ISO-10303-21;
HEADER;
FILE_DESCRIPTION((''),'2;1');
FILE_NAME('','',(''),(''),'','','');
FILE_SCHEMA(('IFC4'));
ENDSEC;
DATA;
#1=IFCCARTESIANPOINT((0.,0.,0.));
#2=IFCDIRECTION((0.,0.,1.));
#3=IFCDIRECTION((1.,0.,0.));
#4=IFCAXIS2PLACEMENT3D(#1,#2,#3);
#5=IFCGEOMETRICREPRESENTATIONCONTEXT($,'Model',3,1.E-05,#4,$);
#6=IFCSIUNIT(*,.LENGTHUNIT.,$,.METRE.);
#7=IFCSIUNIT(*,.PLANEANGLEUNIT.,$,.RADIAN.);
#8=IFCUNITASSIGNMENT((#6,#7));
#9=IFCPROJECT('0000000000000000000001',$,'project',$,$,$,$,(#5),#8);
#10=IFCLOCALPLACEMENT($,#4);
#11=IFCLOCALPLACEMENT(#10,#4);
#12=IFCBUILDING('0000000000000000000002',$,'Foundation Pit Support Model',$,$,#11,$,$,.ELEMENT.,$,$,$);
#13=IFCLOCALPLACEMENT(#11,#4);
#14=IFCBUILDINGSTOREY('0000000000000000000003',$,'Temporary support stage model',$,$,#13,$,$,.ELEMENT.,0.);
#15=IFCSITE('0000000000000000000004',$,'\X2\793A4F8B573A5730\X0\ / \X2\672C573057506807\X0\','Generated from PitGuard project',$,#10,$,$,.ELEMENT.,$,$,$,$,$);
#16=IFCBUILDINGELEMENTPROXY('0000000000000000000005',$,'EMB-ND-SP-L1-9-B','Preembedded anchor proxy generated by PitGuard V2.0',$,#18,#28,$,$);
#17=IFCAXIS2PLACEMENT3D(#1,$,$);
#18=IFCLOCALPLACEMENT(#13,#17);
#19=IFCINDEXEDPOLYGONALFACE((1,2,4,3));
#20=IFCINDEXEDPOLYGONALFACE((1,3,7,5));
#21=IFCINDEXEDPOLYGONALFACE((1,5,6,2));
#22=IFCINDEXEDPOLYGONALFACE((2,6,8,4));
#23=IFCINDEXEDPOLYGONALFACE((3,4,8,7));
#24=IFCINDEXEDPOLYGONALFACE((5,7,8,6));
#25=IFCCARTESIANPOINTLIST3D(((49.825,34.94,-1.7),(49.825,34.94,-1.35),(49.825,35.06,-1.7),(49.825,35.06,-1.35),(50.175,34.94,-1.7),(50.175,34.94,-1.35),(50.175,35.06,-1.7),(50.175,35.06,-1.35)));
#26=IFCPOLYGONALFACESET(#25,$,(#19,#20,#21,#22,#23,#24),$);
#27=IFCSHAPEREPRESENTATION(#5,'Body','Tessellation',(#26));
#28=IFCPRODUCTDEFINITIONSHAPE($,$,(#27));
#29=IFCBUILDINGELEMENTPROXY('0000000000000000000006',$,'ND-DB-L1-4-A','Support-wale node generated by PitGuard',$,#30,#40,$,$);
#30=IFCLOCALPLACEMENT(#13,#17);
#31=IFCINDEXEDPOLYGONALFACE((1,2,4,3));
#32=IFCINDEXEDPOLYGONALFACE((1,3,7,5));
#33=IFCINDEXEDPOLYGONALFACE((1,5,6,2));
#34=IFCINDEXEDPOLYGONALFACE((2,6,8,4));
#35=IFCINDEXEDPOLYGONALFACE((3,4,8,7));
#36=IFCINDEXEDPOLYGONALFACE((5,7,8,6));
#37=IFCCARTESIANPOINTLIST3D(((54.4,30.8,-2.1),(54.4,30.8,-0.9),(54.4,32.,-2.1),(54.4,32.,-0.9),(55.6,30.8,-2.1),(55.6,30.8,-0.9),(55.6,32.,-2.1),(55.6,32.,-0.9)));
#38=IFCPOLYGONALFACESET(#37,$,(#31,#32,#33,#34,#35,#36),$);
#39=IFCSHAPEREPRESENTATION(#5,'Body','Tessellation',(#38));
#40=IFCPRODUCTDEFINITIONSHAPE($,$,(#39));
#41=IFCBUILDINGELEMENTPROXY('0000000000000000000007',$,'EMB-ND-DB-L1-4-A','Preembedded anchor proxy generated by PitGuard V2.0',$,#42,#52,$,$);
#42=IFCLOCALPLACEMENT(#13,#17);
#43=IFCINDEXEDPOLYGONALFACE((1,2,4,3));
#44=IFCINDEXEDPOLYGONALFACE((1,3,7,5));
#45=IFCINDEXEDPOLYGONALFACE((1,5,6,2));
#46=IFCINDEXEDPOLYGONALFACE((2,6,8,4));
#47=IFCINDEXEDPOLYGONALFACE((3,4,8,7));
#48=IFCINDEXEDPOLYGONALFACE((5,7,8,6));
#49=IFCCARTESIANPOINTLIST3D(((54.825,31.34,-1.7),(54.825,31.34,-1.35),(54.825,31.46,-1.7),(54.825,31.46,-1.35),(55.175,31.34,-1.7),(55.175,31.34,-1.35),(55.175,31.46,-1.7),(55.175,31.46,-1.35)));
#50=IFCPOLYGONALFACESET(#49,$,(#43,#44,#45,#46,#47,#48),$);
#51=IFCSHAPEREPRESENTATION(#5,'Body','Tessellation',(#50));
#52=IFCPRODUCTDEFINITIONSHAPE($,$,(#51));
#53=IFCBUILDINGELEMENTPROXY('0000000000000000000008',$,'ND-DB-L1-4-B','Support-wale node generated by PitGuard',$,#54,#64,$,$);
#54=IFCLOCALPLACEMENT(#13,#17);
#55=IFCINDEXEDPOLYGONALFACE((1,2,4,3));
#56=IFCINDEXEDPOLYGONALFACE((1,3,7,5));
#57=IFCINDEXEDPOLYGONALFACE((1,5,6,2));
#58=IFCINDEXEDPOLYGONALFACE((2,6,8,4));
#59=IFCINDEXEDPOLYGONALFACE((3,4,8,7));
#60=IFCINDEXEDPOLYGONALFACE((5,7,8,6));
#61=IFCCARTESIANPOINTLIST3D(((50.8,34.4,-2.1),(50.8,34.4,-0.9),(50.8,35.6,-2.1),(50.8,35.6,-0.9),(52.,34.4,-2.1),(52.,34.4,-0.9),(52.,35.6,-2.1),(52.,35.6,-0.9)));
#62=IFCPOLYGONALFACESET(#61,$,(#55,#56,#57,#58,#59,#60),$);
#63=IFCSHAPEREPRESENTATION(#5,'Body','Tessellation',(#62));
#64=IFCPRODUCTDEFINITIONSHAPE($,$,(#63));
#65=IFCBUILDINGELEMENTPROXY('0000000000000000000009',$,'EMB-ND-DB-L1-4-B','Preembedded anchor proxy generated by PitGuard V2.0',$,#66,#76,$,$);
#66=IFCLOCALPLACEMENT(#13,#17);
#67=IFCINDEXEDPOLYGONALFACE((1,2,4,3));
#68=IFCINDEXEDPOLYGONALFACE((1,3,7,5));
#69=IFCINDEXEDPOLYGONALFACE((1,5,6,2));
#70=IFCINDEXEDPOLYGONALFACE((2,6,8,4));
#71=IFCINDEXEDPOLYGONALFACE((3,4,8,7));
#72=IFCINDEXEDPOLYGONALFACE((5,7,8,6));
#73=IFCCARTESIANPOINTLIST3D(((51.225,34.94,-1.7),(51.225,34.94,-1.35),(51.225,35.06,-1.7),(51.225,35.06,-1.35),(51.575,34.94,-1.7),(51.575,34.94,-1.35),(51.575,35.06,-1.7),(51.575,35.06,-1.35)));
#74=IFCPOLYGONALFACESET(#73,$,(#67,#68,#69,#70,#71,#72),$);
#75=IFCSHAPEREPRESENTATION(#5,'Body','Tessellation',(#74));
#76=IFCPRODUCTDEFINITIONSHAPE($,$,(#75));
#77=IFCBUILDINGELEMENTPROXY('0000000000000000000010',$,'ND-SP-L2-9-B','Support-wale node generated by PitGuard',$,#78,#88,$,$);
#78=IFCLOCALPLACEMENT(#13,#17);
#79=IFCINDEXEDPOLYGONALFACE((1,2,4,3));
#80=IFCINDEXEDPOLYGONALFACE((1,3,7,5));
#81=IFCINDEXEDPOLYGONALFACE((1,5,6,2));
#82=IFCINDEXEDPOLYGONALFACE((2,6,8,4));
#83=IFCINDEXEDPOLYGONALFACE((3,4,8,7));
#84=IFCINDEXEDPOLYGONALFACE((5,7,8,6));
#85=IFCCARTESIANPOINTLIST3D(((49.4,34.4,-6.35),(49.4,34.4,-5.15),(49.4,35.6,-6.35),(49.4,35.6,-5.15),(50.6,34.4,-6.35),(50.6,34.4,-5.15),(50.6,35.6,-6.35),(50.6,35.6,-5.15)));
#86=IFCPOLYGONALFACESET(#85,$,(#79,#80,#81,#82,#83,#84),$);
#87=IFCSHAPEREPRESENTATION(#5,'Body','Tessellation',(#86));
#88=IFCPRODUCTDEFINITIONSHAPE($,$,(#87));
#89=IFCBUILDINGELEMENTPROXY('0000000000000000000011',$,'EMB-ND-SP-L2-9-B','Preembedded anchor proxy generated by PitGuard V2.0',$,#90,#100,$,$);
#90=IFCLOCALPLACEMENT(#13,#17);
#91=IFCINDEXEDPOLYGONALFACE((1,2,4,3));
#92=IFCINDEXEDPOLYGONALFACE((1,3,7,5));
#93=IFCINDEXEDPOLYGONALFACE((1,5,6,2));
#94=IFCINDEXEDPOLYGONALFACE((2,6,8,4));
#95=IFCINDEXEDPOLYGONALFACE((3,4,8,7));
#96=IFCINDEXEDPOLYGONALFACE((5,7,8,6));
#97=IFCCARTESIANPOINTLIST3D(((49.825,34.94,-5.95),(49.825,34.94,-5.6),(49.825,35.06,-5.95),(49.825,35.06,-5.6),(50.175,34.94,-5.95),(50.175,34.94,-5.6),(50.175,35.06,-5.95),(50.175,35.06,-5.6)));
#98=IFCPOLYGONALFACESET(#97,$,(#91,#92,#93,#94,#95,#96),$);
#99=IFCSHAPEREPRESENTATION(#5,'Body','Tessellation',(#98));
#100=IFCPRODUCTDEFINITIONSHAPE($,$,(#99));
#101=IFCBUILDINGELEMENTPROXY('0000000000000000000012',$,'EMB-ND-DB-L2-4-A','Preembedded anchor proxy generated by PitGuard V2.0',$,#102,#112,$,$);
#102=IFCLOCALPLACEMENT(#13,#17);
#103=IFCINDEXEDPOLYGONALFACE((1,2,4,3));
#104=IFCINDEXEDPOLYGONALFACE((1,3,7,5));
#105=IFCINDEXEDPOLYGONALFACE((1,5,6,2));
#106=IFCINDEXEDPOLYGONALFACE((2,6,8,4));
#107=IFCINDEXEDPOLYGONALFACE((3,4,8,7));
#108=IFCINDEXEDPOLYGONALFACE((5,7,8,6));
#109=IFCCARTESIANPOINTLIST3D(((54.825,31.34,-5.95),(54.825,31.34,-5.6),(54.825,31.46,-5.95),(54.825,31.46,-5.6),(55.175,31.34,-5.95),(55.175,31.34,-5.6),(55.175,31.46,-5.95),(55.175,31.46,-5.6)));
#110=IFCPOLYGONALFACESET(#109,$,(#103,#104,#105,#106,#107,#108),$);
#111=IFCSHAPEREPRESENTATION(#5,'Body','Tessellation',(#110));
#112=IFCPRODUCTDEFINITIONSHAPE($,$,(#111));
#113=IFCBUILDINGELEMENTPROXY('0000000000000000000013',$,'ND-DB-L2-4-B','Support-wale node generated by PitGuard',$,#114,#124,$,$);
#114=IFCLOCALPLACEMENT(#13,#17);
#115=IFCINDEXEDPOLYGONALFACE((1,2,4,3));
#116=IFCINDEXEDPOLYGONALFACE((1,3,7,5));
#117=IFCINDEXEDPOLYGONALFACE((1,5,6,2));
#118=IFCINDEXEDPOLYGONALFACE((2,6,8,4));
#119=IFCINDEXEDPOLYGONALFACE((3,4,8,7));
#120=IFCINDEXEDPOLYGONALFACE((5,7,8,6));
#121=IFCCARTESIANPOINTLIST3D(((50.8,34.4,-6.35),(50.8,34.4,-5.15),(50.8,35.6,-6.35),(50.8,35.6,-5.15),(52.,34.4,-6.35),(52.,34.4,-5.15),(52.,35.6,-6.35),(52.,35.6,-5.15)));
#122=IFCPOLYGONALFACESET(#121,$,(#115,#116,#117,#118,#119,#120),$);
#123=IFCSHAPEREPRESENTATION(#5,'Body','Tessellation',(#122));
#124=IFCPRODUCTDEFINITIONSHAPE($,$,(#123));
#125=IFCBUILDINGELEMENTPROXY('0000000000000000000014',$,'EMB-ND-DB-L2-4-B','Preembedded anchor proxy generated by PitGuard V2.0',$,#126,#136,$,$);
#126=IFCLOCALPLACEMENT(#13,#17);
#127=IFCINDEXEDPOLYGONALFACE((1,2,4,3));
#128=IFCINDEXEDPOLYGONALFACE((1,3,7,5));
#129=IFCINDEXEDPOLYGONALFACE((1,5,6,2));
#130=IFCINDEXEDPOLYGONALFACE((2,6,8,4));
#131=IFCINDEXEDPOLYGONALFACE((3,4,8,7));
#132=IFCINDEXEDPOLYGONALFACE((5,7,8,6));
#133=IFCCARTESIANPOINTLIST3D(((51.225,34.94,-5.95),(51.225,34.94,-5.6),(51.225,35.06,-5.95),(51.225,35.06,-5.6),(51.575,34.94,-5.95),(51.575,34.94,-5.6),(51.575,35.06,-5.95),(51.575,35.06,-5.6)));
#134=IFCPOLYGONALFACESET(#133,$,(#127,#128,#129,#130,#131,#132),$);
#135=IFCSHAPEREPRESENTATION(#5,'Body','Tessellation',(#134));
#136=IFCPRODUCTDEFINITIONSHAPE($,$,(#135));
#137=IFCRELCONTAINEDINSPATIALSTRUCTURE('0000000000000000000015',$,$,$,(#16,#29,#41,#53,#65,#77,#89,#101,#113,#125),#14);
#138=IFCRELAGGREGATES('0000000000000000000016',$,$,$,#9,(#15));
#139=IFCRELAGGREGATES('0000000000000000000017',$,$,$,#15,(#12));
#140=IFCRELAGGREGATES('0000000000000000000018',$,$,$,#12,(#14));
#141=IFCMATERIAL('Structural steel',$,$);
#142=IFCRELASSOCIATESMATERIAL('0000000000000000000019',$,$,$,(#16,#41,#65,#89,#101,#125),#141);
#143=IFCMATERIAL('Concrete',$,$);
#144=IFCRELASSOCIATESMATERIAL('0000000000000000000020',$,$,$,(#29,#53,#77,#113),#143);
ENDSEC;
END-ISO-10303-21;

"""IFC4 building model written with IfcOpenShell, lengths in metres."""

from ifc_helpers import new_model, si_unit, frame, origin_with_axes, origin_2d, place, context, project, spatial, rectangle, extrude, material, element, save


model = new_model("IFC4")

# Units and contexts
model_context = context("Model", 3, precision=1e-05, world=origin_with_axes())
ifc_project = project(units=[si_unit("LENGTHUNIT", "METRE"), si_unit("PLANEANGLEUNIT", "RADIAN")], contexts=[model_context])

# Site, building, storey
site_placement = place(None, origin_with_axes())
site = spatial("IfcSite", under=ifc_project, at=site_placement, Name="示例场地 / 本地坐标", Description="Generated from PitGuard project", CompositionType="ELEMENT")
building_placement = place(site_placement, origin_with_axes())
building = spatial("IfcBuilding", under=site, at=building_placement, Name="Foundation Pit Support Model", CompositionType="ELEMENT")
storey_placement = place(building_placement, origin_with_axes())
storey = spatial("IfcBuildingStorey", under=building, at=storey_placement, Name="Temporary support stage model", CompositionType="ELEMENT", Elevation=0.0)

# Shared definitions
ifc_material_1 = material(Name="Concrete")

# Shared definitions
ifc_material_2 = material(Name="Structural steel")

# Building element proxies
proxy_1_placement = place(storey_placement, frame((50.0, 35.0, -1.7), z_axis=(0.0, 0.0, 1.0), x_axis=(1.0, 0.0, 0.0)))
element("IfcBuildingElementProxy", 1, at=proxy_1_placement, inside=storey, material=ifc_material_2, Name="EMB-ND-SP-L1-9-B", Description="Preembedded anchor proxy generated by PitGuard V2.0", context=model_context, shape_type="SweptSolid", body=[
    extrude(rectangle(XDim=0.35, YDim=0.12, at=origin_2d()), origin_with_axes(), (0.0, 0.0, 1.0), 0.35),
])
proxy_2_placement = place(storey_placement, frame((55.0, 31.4, -2.1), z_axis=(0.0, 0.0, 1.0), x_axis=(1.0, 0.0, 0.0)))
element("IfcBuildingElementProxy", 2, at=proxy_2_placement, inside=storey, material=ifc_material_1, Name="ND-DB-L1-4-A", Description="Support-wale node generated by PitGuard", context=model_context, shape_type="SweptSolid", body=[
    extrude(rectangle(XDim=1.2, YDim=1.2, at=origin_2d()), origin_with_axes(), (0.0, 0.0, 1.0), 1.2),
])
proxy_3_placement = place(storey_placement, frame((55.0, 31.4, -1.7), z_axis=(0.0, 0.0, 1.0), x_axis=(1.0, 0.0, 0.0)))
element("IfcBuildingElementProxy", 3, at=proxy_3_placement, inside=storey, material=ifc_material_2, Name="EMB-ND-DB-L1-4-A", Description="Preembedded anchor proxy generated by PitGuard V2.0", context=model_context, shape_type="SweptSolid", body=[
    extrude(rectangle(XDim=0.35, YDim=0.12, at=origin_2d()), origin_with_axes(), (0.0, 0.0, 1.0), 0.35),
])
proxy_4_placement = place(storey_placement, frame((51.4, 35.0, -2.1), z_axis=(0.0, 0.0, 1.0), x_axis=(1.0, 0.0, 0.0)))
element("IfcBuildingElementProxy", 4, at=proxy_4_placement, inside=storey, material=ifc_material_1, Name="ND-DB-L1-4-B", Description="Support-wale node generated by PitGuard", context=model_context, shape_type="SweptSolid", body=[
    extrude(rectangle(XDim=1.2, YDim=1.2, at=origin_2d()), origin_with_axes(), (0.0, 0.0, 1.0), 1.2),
])
proxy_5_placement = place(storey_placement, frame((51.4, 35.0, -1.7), z_axis=(0.0, 0.0, 1.0), x_axis=(1.0, 0.0, 0.0)))
element("IfcBuildingElementProxy", 5, at=proxy_5_placement, inside=storey, material=ifc_material_2, Name="EMB-ND-DB-L1-4-B", Description="Preembedded anchor proxy generated by PitGuard V2.0", context=model_context, shape_type="SweptSolid", body=[
    extrude(rectangle(XDim=0.35, YDim=0.12, at=origin_2d()), origin_with_axes(), (0.0, 0.0, 1.0), 0.35),
])
proxy_6_placement = place(storey_placement, frame((50.0, 35.0, -6.35), z_axis=(0.0, 0.0, 1.0), x_axis=(1.0, 0.0, 0.0)))
element("IfcBuildingElementProxy", 6, at=proxy_6_placement, inside=storey, material=ifc_material_1, Name="ND-SP-L2-9-B", Description="Support-wale node generated by PitGuard", context=model_context, shape_type="SweptSolid", body=[
    extrude(rectangle(XDim=1.2, YDim=1.2, at=origin_2d()), origin_with_axes(), (0.0, 0.0, 1.0), 1.2),
])
for number, where, z_axis, x_axis, name in (
    (7, (50.0, 35.0, -5.95), (0.0, 0.0, 1.0), (1.0, 0.0, 0.0), "EMB-ND-SP-L2-9-B"),
    (8, (55.0, 31.4, -5.95), (0.0, 0.0, 1.0), (1.0, 0.0, 0.0), "EMB-ND-DB-L2-4-A"),
):
    element("IfcBuildingElementProxy", number, at=place(storey_placement, frame(where, z_axis=z_axis, x_axis=x_axis)), inside=storey, material=ifc_material_2, Name=name, Description="Preembedded anchor proxy generated by PitGuard V2.0", context=model_context, shape_type="SweptSolid", body=[
        extrude(rectangle(XDim=0.35, YDim=0.12, at=origin_2d()), origin_with_axes(), (0.0, 0.0, 1.0), 0.35),
    ])
proxy_7_placement = place(storey_placement, frame((51.4, 35.0, -6.35), z_axis=(0.0, 0.0, 1.0), x_axis=(1.0, 0.0, 0.0)))
element("IfcBuildingElementProxy", 9, at=proxy_7_placement, inside=storey, material=ifc_material_1, Name="ND-DB-L2-4-B", Description="Support-wale node generated by PitGuard", context=model_context, shape_type="SweptSolid", body=[
    extrude(rectangle(XDim=1.2, YDim=1.2, at=origin_2d()), origin_with_axes(), (0.0, 0.0, 1.0), 1.2),
])
proxy_8_placement = place(storey_placement, frame((51.4, 35.0, -5.95), z_axis=(0.0, 0.0, 1.0), x_axis=(1.0, 0.0, 0.0)))
element("IfcBuildingElementProxy", 10, at=proxy_8_placement, inside=storey, material=ifc_material_2, Name="EMB-ND-DB-L2-4-B", Description="Preembedded anchor proxy generated by PitGuard V2.0", context=model_context, shape_type="SweptSolid", body=[
    extrude(rectangle(XDim=0.35, YDim=0.12, at=origin_2d()), origin_with_axes(), (0.0, 0.0, 1.0), 0.35),
])

save(model, "model.ifc")
